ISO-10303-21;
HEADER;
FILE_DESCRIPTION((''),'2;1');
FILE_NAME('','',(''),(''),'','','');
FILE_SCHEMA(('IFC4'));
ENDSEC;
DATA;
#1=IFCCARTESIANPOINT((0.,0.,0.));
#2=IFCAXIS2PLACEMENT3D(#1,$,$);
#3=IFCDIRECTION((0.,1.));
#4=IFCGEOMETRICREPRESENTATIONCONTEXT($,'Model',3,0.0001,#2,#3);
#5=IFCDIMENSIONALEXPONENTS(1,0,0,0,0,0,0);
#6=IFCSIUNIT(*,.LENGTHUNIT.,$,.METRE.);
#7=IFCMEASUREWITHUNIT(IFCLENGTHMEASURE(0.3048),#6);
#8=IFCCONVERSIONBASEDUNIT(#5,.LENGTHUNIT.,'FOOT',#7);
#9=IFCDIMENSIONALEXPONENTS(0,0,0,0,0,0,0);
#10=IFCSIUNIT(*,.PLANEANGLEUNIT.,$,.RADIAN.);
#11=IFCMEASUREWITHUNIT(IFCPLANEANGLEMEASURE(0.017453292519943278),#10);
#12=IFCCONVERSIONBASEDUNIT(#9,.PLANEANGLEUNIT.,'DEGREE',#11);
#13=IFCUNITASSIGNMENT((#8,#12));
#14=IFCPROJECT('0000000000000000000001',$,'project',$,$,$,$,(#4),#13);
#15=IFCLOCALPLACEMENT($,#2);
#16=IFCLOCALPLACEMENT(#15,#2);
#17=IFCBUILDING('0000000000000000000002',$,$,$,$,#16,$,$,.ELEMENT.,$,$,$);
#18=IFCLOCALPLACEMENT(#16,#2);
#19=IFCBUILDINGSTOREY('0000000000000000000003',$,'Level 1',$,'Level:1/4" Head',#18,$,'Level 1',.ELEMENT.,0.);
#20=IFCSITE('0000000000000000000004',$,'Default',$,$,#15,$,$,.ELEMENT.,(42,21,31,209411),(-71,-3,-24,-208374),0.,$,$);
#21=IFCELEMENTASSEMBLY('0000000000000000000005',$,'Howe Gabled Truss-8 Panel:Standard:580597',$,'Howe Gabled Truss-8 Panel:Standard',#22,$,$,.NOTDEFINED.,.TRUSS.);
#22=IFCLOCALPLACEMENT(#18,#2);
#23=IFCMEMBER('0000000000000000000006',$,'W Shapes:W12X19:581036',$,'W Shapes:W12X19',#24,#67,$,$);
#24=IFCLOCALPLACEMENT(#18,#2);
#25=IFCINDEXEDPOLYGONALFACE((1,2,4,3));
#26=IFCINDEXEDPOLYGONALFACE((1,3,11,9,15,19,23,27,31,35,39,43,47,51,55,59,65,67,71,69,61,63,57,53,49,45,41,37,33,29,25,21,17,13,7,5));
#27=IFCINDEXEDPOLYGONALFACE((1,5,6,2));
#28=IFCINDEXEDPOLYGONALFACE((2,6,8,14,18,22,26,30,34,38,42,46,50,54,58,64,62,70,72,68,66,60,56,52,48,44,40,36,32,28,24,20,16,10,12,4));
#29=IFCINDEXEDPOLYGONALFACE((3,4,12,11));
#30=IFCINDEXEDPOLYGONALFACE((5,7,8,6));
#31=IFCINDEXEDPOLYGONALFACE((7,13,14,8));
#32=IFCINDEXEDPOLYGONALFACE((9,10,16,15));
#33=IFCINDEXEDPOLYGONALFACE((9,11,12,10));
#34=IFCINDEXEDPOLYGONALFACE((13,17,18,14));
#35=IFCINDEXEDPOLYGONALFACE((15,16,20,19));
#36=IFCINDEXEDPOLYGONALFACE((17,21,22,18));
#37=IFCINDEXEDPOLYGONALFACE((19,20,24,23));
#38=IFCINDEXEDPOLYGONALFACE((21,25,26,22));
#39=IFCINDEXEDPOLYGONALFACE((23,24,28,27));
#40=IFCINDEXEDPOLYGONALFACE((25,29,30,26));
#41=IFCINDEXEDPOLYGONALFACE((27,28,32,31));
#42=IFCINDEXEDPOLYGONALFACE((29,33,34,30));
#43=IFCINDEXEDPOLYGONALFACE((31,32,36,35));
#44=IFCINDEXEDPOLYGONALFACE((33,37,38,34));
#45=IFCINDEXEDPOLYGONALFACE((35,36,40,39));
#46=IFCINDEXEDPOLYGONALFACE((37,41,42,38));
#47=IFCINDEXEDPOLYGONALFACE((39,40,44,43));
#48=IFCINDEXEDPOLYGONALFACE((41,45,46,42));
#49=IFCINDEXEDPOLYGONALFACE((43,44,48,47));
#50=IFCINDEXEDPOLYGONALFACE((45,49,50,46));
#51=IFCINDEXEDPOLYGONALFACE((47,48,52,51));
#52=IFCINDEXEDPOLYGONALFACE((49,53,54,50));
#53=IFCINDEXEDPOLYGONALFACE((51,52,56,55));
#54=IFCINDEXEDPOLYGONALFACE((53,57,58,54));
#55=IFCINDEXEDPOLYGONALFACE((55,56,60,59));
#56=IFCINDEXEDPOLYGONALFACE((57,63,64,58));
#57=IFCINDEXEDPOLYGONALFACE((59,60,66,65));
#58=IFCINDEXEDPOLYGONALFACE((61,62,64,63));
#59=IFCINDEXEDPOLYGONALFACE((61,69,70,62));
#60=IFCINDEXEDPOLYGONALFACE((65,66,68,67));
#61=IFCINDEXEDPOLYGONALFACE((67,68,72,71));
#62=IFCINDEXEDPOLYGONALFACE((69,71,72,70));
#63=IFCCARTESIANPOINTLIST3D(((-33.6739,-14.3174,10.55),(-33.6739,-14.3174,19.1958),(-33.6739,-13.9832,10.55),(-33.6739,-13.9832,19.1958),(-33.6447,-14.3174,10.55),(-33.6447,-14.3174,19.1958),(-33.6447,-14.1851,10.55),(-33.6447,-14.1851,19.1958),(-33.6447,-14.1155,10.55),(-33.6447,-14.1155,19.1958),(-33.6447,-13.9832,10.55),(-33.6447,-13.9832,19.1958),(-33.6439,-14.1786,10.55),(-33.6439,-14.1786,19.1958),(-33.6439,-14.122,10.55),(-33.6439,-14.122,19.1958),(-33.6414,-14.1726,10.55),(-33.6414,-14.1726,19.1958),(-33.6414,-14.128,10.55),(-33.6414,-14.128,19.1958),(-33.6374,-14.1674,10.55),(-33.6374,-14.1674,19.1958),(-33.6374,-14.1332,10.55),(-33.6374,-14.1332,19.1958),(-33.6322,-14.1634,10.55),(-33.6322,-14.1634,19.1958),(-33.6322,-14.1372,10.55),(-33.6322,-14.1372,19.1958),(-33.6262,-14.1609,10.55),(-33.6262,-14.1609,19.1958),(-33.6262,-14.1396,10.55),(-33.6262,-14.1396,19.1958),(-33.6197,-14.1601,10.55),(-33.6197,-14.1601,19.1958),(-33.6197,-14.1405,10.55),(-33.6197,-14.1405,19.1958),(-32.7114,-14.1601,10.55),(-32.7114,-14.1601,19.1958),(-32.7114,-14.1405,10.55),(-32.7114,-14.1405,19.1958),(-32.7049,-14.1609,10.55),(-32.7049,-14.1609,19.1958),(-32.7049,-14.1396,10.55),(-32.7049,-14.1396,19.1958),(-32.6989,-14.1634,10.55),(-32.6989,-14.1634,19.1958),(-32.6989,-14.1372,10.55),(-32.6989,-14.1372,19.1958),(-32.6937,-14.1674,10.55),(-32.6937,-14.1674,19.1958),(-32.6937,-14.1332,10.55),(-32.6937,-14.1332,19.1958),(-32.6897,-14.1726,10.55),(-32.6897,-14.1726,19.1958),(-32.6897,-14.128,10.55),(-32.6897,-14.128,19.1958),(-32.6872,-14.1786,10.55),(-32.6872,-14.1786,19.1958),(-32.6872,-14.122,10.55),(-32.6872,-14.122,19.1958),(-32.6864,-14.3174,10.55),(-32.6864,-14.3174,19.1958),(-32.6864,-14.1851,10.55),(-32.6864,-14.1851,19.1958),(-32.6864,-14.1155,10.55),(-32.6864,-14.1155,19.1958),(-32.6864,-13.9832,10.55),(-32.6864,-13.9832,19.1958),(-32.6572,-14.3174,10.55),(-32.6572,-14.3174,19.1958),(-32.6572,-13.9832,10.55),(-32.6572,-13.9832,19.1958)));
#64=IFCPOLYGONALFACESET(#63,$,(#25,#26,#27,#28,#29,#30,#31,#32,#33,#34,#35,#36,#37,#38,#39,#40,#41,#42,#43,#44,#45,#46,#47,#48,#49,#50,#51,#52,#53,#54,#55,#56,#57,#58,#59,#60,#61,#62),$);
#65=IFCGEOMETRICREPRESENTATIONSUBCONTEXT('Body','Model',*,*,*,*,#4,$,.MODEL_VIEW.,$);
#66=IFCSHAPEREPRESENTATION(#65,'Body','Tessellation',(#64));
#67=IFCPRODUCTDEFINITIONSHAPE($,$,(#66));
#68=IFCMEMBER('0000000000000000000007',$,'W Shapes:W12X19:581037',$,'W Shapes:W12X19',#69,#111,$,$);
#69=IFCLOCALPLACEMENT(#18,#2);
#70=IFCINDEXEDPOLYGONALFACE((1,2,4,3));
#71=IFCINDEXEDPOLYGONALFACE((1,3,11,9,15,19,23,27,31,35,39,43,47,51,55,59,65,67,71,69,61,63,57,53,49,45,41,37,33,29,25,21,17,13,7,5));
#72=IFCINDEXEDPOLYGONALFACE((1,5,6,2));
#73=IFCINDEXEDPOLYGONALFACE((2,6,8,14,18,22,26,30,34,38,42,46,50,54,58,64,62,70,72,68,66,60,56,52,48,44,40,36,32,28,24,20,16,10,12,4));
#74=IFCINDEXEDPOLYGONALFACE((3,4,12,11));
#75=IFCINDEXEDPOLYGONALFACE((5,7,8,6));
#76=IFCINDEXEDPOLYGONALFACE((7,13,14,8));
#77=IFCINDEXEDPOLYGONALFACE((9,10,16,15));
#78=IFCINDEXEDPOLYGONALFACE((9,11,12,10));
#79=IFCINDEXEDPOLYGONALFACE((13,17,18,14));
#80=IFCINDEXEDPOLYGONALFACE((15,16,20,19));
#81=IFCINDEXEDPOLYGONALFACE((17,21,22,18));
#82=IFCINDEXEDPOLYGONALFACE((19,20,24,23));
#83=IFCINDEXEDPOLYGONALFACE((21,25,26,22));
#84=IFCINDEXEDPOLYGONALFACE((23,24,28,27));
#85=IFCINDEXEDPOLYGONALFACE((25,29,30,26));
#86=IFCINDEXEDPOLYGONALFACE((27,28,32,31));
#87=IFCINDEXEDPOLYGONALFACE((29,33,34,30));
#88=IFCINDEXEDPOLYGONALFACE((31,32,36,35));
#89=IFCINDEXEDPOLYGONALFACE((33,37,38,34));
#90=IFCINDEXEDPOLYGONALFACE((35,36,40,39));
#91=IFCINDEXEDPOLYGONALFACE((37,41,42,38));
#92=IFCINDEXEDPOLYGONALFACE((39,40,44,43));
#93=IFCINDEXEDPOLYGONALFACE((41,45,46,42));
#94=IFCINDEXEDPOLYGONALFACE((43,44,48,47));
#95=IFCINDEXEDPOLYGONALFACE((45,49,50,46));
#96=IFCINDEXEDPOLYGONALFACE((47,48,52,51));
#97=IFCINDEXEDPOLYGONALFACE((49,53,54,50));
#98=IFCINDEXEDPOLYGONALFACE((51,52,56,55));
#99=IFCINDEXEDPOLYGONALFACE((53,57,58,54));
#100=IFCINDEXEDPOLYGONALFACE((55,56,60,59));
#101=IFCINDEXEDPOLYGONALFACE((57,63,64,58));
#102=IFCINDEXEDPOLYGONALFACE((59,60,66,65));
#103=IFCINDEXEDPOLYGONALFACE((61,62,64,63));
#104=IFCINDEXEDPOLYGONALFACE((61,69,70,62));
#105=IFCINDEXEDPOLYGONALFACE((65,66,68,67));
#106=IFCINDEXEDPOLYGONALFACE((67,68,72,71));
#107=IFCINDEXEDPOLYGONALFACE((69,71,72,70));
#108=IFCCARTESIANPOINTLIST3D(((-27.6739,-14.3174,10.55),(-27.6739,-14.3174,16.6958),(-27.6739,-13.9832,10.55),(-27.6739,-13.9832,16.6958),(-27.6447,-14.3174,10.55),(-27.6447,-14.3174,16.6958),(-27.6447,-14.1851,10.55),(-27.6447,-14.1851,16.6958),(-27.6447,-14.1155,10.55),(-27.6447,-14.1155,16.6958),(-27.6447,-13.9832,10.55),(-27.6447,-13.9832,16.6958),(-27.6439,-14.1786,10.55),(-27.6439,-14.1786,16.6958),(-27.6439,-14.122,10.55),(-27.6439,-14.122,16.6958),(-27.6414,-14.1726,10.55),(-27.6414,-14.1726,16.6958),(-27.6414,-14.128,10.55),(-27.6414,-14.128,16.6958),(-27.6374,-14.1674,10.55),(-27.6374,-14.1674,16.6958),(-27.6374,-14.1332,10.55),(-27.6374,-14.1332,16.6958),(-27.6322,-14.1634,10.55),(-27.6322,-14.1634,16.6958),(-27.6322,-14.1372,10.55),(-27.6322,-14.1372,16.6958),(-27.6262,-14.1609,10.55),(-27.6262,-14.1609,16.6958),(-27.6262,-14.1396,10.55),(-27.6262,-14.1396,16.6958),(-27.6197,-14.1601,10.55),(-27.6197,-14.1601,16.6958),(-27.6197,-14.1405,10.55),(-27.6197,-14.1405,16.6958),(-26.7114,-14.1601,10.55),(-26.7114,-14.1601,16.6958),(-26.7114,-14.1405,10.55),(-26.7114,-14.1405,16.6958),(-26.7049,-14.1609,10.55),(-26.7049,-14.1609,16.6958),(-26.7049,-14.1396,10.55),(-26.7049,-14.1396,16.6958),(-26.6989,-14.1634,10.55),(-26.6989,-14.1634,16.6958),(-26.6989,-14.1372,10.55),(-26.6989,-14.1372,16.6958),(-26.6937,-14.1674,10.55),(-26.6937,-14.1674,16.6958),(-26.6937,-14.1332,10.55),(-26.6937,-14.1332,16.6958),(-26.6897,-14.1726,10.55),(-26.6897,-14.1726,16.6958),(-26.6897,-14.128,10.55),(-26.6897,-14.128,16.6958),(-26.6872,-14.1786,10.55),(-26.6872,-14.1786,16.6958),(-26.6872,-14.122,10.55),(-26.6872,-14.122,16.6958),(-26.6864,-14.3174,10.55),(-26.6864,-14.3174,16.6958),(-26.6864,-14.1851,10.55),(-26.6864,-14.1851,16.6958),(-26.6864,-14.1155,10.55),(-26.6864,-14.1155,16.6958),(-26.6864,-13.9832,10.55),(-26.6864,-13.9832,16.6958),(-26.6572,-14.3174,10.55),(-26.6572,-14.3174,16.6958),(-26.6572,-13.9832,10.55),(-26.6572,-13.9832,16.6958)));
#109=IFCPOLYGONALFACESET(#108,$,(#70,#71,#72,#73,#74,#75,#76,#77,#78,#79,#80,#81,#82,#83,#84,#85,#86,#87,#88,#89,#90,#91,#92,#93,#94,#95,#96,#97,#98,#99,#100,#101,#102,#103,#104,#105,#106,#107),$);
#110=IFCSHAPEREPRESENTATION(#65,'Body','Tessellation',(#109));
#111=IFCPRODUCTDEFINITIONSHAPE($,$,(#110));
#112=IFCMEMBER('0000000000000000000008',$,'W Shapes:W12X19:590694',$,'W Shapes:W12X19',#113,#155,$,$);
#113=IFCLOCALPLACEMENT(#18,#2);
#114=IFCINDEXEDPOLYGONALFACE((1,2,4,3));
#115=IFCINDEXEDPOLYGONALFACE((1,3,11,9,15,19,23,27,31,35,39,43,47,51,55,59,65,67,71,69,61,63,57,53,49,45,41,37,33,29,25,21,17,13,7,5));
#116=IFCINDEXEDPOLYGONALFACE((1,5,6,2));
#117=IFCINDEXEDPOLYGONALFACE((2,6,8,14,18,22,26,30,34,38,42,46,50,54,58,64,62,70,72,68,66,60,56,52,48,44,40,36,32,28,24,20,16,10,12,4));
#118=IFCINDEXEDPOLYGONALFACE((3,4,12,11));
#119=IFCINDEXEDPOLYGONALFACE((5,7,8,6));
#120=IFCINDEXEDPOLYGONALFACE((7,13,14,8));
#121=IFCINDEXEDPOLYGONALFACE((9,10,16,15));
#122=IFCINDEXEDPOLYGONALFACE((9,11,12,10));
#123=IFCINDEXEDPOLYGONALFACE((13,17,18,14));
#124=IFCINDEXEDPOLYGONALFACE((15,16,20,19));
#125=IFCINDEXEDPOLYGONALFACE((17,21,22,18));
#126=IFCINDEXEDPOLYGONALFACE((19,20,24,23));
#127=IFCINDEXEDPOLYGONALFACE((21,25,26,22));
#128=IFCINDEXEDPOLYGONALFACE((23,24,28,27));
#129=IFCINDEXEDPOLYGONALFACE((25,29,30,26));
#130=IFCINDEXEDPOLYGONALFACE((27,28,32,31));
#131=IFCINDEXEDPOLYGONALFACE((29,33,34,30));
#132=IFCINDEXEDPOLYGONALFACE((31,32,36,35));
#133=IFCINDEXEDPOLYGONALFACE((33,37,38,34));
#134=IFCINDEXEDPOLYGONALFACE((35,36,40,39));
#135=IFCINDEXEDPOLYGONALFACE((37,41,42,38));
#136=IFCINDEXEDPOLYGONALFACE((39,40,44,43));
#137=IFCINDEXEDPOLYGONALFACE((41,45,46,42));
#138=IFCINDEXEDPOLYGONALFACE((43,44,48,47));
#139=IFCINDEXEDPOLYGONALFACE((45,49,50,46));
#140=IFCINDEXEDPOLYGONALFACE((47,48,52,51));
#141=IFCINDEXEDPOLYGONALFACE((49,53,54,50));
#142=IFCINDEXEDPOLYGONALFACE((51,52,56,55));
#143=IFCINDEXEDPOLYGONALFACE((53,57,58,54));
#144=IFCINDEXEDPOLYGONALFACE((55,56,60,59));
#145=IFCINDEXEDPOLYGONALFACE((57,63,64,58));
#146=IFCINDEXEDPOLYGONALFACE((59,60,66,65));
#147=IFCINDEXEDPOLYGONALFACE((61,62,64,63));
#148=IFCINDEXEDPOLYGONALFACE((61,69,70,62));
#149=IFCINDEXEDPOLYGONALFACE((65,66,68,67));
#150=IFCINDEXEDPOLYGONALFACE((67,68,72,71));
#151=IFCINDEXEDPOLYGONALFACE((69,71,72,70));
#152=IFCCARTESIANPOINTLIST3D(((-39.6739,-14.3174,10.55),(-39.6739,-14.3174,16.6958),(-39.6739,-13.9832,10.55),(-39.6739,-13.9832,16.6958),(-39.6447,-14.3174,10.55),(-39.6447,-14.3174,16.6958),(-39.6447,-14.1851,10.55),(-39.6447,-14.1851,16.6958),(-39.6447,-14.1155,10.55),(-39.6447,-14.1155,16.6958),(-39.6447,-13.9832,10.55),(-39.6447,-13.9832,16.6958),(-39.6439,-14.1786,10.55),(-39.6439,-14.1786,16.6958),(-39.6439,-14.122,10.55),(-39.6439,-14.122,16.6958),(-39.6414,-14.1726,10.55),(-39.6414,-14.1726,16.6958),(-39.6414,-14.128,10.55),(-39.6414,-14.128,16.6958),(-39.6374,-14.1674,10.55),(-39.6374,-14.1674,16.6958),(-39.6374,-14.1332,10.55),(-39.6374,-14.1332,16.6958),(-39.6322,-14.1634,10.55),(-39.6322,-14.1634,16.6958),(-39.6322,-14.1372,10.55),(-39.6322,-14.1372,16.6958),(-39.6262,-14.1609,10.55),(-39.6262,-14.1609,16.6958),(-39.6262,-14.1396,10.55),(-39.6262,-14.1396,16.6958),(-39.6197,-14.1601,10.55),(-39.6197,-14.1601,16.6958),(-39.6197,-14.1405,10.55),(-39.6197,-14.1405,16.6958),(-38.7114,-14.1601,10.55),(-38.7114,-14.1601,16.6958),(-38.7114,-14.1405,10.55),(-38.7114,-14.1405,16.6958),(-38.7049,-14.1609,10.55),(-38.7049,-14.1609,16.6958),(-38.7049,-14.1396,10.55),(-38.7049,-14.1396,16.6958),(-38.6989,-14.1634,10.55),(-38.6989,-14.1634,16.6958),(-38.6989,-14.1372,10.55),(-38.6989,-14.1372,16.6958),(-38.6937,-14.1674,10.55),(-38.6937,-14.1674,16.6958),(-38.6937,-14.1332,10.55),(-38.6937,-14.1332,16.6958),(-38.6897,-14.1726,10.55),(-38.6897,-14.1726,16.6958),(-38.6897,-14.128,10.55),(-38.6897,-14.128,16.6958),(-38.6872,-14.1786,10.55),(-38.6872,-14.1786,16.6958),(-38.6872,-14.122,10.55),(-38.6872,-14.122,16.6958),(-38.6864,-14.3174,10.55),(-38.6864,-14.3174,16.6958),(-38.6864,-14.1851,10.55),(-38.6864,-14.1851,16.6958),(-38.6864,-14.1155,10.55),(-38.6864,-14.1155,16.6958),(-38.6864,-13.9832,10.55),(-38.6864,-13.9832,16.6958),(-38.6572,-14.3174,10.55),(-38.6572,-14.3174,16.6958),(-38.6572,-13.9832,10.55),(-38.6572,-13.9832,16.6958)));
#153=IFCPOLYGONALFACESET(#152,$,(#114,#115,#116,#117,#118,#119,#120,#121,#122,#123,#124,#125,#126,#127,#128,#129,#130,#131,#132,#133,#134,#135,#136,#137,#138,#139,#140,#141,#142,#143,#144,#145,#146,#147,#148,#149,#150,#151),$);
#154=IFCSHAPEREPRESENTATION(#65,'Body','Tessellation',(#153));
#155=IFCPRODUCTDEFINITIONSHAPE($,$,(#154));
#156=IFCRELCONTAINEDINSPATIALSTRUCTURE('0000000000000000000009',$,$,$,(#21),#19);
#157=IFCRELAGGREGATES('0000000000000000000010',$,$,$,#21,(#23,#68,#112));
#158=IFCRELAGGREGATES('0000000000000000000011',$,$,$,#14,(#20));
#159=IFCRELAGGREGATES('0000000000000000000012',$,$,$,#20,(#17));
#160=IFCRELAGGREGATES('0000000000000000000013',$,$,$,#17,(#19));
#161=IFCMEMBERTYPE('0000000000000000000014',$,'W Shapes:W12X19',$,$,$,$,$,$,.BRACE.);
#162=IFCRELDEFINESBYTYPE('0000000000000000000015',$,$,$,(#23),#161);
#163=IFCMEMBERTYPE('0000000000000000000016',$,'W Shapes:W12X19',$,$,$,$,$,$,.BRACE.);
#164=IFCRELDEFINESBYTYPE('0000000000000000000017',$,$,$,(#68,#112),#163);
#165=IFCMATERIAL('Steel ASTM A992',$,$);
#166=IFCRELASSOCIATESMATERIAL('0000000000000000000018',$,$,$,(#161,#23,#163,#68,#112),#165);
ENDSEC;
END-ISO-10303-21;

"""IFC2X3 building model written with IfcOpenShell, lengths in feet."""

from ifc_helpers import new_model, entity, si_unit, converted_unit, direction, frame, frame_2d, origin, place, context, subcontext, project, spatial, polyline, circle_curve, parameter, trimmed, segment, composite_curve, outline, extrude, source, transform, mapped, material, type_object, type_shapes, element, aggregate, save


model = new_model("IFC2X3")

# Units and contexts
model_context = context("Model", 3, precision=0.0001, world=origin(), true_north=direction((0.0, 1.0)))
body_context = subcontext(model_context, "Body", "Model", "MODEL_VIEW")
ifc_project = project(units=[converted_unit("LENGTHUNIT", "FOOT", entity("IfcLengthMeasure", 0.3048), si_unit("LENGTHUNIT", "METRE"), dimensions=[1, 0, 0, 0, 0, 0, 0]), converted_unit("PLANEANGLEUNIT", "DEGREE", entity("IfcPlaneAngleMeasure", 0.017453292519943278), si_unit("PLANEANGLEUNIT", "RADIAN"), dimensions=[0, 0, 0, 0, 0, 0, 0])], contexts=[model_context])

# Site, building, storey
site_placement = place(None, origin())
site = spatial("IfcSite", under=ifc_project, at=site_placement, Name="Default", CompositionType="ELEMENT", RefLatitude=(42, 21, 31, 209411), RefLongitude=(-71, -3, -24, -208374), RefElevation=0.0)
building_placement = place(site_placement, origin())
building = spatial("IfcBuilding", under=site, at=building_placement, CompositionType="ELEMENT")
storey_placement = place(building_placement, origin())
storey = spatial("IfcBuildingStorey", under=building, at=storey_placement, Name="Level 1", ObjectType="Level:1/4\" Head", LongName="Level 1", CompositionType="ELEMENT", Elevation=0.0)

# Element assembly, members
assembly_placement = place(storey_placement, origin())
assembly = element("IfcElementAssembly", 1, at=assembly_placement, inside=storey, Name="Howe Gabled Truss-8 Panel:Standard:580597", ObjectType="Howe Gabled Truss-8 Panel:Standard", AssemblyPlace="NOTDEFINED", PredefinedType="TRUSS")
ifc_material = material(Name="Steel ASTM A992")
member_type_1 = type_object("IfcMemberType", Name="W Shapes:W12X19", PredefinedType="BRACE", material=ifc_material)
shared_shape_1 = source(origin(), body_context, "Body", "SweptSolid", [
    extrude(outline(composite_curve([segment(polyline([(-0.1671, -0.4792), (-0.1671, -0.5083)]), True, "CONTINUOUS"), segment(polyline([(-0.1671, -0.5083), (0.1671, -0.5083)]), True, "CONTINUOUS"), segment(polyline([(0.1671, -0.5083), (0.1671, -0.4792)]), True, "CONTINUOUS"), segment(polyline([(0.1671, -0.4792), (0.0348, -0.4792)]), True, "CONTINUOUS"), segment(trimmed(circle_curve(frame_2d((0.0348, -0.4542), x_axis=(1.0, 0.0)), 0.025), [parameter(180.0)], [parameter(270.0)], True, "PARAMETER"), False, "CONTINUOUS"), segment(polyline([(0.0098, -0.4542), (0.0098, 0.4542)]), True, "CONTINUOUS"), segment(trimmed(circle_curve(frame_2d((0.0348, 0.4542), x_axis=(1.0, 0.0)), 0.025), [parameter(90.0)], [parameter(180.0)], True, "PARAMETER"), False, "CONTINUOUS"), segment(polyline([(0.0348, 0.4792), (0.1671, 0.4792)]), True, "CONTINUOUS"), segment(polyline([(0.1671, 0.4792), (0.1671, 0.5083)]), True, "CONTINUOUS"), segment(polyline([(0.1671, 0.5083), (-0.1671, 0.5083)]), True, "CONTINUOUS"), segment(polyline([(-0.1671, 0.5083), (-0.1671, 0.4792)]), True, "CONTINUOUS"), segment(polyline([(-0.1671, 0.4792), (-0.0348, 0.4792)]), True, "CONTINUOUS"), segment(trimmed(circle_curve(frame_2d((-0.0348, 0.4542), x_axis=(1.0, 0.0)), 0.025), [parameter(360.0)], [parameter(90.0)], True, "PARAMETER"), False, "CONTINUOUS"), segment(polyline([(-0.0098, 0.4542), (-0.0098, -0.4542)]), True, "CONTINUOUS"), segment(trimmed(circle_curve(frame_2d((-0.0348, -0.4542), x_axis=(1.0, 0.0)), 0.025), [parameter(270.0)], [parameter(360.0)], True, "PARAMETER"), False, "CONTINUOUS"), segment(polyline([(-0.0348, -0.4792), (-0.1671, -0.4792)]), True, "CONTINUOUS")], self_intersect=False)), frame((-4.45, 0.0, 0.0), z_axis=(-1.0, 0.0, 0.0), x_axis=(0.0, -1.0, 0.0)), (0.0, 0.0, -1.0), 8.6458),
])
type_shapes(member_type_1, [shared_shape_1])
member_1_placement = place(assembly_placement, frame((-33.1655, -14.1503, 15.0), z_axis=(1.0, 0.0, 0.0), x_axis=(0.0, 0.0, 1.0)))
member_1 = element("IfcMember", 2, at=member_1_placement, type_object=member_type_1, material=ifc_material, Name="W Shapes:W12X19:581036", ObjectType="W Shapes:W12X19", context=body_context, shape_type="MappedRepresentation", body=[
    mapped(shared_shape_1, transform((0.0, 0.0, 0.0), scale=1.0)),
])
member_type_2 = type_object("IfcMemberType", Name="W Shapes:W12X19", PredefinedType="BRACE", material=ifc_material)
shared_shape_2 = source(origin(), body_context, "Body", "SweptSolid", [
    extrude(outline(composite_curve([segment(polyline([(-0.1671, -0.4792), (-0.1671, -0.5083)]), True, "CONTINUOUS"), segment(polyline([(-0.1671, -0.5083), (0.1671, -0.5083)]), True, "CONTINUOUS"), segment(polyline([(0.1671, -0.5083), (0.1671, -0.4792)]), True, "CONTINUOUS"), segment(polyline([(0.1671, -0.4792), (0.0348, -0.4792)]), True, "CONTINUOUS"), segment(trimmed(circle_curve(frame_2d((0.0348, -0.4542), x_axis=(0.0, -1.0)), 0.025), [parameter(270.0)], [parameter(360.0)], True, "PARAMETER"), False, "CONTINUOUS"), segment(polyline([(0.0098, -0.4542), (0.0098, 0.4542)]), True, "CONTINUOUS"), segment(trimmed(circle_curve(frame_2d((0.0348, 0.4542), x_axis=(-1.0, 0.0)), 0.025), [parameter(270.0)], [parameter(360.0)], True, "PARAMETER"), False, "CONTINUOUS"), segment(polyline([(0.0348, 0.4792), (0.1671, 0.4792)]), True, "CONTINUOUS"), segment(polyline([(0.1671, 0.4792), (0.1671, 0.5083)]), True, "CONTINUOUS"), segment(polyline([(0.1671, 0.5083), (-0.1671, 0.5083)]), True, "CONTINUOUS"), segment(polyline([(-0.1671, 0.5083), (-0.1671, 0.4792)]), True, "CONTINUOUS"), segment(polyline([(-0.1671, 0.4792), (-0.0348, 0.4792)]), True, "CONTINUOUS"), segment(trimmed(circle_curve(frame_2d((-0.0348, 0.4542), x_axis=(0.0, 1.0)), 0.025), [parameter(270.0)], [parameter(0.0)], True, "PARAMETER"), False, "CONTINUOUS"), segment(polyline([(-0.0098, 0.4542), (-0.0098, -0.4542)]), True, "CONTINUOUS"), segment(trimmed(circle_curve(frame_2d((-0.0348, -0.4542), x_axis=(1.0, 0.0)), 0.025), [parameter(270.0)], [parameter(0.0)], True, "PARAMETER"), False, "CONTINUOUS"), segment(polyline([(-0.0348, -0.4792), (-0.1671, -0.4792)]), True, "CONTINUOUS")], self_intersect=False)), frame((-3.2, 0.0, 0.0), z_axis=(-1.0, 0.0, 0.0), x_axis=(0.0, -1.0, 0.0)), (0.0, 0.0, -1.0), 6.1458),
])
type_shapes(member_type_2, [shared_shape_2])
member_2_placement = place(assembly_placement, frame((-27.1655, -14.1503, 13.75), z_axis=(1.0, 0.0, 0.0), x_axis=(0.0, 0.0, 1.0)))
member_2 = element("IfcMember", 3, at=member_2_placement, type_object=member_type_2, material=ifc_material, Name="W Shapes:W12X19:581037", ObjectType="W Shapes:W12X19", context=body_context, shape_type="MappedRepresentation", body=[
    mapped(shared_shape_2, transform((0.0, 0.0, 0.0), scale=1.0)),
])
member_3_placement = place(assembly_placement, frame((-39.1655, -14.1503, 13.75), z_axis=(1.0, 0.0, 0.0), x_axis=(0.0, 0.0, 1.0)))
member_3 = element("IfcMember", 4, at=member_3_placement, type_object=member_type_2, material=ifc_material, Name="W Shapes:W12X19:590694", ObjectType="W Shapes:W12X19", context=body_context, shape_type="MappedRepresentation", body=[
    mapped(shared_shape_2, transform((0.0, 0.0, 0.0), scale=1.0)),
])
aggregate(assembly, [member_1, member_2, member_3])

save(model, "model.ifc")
